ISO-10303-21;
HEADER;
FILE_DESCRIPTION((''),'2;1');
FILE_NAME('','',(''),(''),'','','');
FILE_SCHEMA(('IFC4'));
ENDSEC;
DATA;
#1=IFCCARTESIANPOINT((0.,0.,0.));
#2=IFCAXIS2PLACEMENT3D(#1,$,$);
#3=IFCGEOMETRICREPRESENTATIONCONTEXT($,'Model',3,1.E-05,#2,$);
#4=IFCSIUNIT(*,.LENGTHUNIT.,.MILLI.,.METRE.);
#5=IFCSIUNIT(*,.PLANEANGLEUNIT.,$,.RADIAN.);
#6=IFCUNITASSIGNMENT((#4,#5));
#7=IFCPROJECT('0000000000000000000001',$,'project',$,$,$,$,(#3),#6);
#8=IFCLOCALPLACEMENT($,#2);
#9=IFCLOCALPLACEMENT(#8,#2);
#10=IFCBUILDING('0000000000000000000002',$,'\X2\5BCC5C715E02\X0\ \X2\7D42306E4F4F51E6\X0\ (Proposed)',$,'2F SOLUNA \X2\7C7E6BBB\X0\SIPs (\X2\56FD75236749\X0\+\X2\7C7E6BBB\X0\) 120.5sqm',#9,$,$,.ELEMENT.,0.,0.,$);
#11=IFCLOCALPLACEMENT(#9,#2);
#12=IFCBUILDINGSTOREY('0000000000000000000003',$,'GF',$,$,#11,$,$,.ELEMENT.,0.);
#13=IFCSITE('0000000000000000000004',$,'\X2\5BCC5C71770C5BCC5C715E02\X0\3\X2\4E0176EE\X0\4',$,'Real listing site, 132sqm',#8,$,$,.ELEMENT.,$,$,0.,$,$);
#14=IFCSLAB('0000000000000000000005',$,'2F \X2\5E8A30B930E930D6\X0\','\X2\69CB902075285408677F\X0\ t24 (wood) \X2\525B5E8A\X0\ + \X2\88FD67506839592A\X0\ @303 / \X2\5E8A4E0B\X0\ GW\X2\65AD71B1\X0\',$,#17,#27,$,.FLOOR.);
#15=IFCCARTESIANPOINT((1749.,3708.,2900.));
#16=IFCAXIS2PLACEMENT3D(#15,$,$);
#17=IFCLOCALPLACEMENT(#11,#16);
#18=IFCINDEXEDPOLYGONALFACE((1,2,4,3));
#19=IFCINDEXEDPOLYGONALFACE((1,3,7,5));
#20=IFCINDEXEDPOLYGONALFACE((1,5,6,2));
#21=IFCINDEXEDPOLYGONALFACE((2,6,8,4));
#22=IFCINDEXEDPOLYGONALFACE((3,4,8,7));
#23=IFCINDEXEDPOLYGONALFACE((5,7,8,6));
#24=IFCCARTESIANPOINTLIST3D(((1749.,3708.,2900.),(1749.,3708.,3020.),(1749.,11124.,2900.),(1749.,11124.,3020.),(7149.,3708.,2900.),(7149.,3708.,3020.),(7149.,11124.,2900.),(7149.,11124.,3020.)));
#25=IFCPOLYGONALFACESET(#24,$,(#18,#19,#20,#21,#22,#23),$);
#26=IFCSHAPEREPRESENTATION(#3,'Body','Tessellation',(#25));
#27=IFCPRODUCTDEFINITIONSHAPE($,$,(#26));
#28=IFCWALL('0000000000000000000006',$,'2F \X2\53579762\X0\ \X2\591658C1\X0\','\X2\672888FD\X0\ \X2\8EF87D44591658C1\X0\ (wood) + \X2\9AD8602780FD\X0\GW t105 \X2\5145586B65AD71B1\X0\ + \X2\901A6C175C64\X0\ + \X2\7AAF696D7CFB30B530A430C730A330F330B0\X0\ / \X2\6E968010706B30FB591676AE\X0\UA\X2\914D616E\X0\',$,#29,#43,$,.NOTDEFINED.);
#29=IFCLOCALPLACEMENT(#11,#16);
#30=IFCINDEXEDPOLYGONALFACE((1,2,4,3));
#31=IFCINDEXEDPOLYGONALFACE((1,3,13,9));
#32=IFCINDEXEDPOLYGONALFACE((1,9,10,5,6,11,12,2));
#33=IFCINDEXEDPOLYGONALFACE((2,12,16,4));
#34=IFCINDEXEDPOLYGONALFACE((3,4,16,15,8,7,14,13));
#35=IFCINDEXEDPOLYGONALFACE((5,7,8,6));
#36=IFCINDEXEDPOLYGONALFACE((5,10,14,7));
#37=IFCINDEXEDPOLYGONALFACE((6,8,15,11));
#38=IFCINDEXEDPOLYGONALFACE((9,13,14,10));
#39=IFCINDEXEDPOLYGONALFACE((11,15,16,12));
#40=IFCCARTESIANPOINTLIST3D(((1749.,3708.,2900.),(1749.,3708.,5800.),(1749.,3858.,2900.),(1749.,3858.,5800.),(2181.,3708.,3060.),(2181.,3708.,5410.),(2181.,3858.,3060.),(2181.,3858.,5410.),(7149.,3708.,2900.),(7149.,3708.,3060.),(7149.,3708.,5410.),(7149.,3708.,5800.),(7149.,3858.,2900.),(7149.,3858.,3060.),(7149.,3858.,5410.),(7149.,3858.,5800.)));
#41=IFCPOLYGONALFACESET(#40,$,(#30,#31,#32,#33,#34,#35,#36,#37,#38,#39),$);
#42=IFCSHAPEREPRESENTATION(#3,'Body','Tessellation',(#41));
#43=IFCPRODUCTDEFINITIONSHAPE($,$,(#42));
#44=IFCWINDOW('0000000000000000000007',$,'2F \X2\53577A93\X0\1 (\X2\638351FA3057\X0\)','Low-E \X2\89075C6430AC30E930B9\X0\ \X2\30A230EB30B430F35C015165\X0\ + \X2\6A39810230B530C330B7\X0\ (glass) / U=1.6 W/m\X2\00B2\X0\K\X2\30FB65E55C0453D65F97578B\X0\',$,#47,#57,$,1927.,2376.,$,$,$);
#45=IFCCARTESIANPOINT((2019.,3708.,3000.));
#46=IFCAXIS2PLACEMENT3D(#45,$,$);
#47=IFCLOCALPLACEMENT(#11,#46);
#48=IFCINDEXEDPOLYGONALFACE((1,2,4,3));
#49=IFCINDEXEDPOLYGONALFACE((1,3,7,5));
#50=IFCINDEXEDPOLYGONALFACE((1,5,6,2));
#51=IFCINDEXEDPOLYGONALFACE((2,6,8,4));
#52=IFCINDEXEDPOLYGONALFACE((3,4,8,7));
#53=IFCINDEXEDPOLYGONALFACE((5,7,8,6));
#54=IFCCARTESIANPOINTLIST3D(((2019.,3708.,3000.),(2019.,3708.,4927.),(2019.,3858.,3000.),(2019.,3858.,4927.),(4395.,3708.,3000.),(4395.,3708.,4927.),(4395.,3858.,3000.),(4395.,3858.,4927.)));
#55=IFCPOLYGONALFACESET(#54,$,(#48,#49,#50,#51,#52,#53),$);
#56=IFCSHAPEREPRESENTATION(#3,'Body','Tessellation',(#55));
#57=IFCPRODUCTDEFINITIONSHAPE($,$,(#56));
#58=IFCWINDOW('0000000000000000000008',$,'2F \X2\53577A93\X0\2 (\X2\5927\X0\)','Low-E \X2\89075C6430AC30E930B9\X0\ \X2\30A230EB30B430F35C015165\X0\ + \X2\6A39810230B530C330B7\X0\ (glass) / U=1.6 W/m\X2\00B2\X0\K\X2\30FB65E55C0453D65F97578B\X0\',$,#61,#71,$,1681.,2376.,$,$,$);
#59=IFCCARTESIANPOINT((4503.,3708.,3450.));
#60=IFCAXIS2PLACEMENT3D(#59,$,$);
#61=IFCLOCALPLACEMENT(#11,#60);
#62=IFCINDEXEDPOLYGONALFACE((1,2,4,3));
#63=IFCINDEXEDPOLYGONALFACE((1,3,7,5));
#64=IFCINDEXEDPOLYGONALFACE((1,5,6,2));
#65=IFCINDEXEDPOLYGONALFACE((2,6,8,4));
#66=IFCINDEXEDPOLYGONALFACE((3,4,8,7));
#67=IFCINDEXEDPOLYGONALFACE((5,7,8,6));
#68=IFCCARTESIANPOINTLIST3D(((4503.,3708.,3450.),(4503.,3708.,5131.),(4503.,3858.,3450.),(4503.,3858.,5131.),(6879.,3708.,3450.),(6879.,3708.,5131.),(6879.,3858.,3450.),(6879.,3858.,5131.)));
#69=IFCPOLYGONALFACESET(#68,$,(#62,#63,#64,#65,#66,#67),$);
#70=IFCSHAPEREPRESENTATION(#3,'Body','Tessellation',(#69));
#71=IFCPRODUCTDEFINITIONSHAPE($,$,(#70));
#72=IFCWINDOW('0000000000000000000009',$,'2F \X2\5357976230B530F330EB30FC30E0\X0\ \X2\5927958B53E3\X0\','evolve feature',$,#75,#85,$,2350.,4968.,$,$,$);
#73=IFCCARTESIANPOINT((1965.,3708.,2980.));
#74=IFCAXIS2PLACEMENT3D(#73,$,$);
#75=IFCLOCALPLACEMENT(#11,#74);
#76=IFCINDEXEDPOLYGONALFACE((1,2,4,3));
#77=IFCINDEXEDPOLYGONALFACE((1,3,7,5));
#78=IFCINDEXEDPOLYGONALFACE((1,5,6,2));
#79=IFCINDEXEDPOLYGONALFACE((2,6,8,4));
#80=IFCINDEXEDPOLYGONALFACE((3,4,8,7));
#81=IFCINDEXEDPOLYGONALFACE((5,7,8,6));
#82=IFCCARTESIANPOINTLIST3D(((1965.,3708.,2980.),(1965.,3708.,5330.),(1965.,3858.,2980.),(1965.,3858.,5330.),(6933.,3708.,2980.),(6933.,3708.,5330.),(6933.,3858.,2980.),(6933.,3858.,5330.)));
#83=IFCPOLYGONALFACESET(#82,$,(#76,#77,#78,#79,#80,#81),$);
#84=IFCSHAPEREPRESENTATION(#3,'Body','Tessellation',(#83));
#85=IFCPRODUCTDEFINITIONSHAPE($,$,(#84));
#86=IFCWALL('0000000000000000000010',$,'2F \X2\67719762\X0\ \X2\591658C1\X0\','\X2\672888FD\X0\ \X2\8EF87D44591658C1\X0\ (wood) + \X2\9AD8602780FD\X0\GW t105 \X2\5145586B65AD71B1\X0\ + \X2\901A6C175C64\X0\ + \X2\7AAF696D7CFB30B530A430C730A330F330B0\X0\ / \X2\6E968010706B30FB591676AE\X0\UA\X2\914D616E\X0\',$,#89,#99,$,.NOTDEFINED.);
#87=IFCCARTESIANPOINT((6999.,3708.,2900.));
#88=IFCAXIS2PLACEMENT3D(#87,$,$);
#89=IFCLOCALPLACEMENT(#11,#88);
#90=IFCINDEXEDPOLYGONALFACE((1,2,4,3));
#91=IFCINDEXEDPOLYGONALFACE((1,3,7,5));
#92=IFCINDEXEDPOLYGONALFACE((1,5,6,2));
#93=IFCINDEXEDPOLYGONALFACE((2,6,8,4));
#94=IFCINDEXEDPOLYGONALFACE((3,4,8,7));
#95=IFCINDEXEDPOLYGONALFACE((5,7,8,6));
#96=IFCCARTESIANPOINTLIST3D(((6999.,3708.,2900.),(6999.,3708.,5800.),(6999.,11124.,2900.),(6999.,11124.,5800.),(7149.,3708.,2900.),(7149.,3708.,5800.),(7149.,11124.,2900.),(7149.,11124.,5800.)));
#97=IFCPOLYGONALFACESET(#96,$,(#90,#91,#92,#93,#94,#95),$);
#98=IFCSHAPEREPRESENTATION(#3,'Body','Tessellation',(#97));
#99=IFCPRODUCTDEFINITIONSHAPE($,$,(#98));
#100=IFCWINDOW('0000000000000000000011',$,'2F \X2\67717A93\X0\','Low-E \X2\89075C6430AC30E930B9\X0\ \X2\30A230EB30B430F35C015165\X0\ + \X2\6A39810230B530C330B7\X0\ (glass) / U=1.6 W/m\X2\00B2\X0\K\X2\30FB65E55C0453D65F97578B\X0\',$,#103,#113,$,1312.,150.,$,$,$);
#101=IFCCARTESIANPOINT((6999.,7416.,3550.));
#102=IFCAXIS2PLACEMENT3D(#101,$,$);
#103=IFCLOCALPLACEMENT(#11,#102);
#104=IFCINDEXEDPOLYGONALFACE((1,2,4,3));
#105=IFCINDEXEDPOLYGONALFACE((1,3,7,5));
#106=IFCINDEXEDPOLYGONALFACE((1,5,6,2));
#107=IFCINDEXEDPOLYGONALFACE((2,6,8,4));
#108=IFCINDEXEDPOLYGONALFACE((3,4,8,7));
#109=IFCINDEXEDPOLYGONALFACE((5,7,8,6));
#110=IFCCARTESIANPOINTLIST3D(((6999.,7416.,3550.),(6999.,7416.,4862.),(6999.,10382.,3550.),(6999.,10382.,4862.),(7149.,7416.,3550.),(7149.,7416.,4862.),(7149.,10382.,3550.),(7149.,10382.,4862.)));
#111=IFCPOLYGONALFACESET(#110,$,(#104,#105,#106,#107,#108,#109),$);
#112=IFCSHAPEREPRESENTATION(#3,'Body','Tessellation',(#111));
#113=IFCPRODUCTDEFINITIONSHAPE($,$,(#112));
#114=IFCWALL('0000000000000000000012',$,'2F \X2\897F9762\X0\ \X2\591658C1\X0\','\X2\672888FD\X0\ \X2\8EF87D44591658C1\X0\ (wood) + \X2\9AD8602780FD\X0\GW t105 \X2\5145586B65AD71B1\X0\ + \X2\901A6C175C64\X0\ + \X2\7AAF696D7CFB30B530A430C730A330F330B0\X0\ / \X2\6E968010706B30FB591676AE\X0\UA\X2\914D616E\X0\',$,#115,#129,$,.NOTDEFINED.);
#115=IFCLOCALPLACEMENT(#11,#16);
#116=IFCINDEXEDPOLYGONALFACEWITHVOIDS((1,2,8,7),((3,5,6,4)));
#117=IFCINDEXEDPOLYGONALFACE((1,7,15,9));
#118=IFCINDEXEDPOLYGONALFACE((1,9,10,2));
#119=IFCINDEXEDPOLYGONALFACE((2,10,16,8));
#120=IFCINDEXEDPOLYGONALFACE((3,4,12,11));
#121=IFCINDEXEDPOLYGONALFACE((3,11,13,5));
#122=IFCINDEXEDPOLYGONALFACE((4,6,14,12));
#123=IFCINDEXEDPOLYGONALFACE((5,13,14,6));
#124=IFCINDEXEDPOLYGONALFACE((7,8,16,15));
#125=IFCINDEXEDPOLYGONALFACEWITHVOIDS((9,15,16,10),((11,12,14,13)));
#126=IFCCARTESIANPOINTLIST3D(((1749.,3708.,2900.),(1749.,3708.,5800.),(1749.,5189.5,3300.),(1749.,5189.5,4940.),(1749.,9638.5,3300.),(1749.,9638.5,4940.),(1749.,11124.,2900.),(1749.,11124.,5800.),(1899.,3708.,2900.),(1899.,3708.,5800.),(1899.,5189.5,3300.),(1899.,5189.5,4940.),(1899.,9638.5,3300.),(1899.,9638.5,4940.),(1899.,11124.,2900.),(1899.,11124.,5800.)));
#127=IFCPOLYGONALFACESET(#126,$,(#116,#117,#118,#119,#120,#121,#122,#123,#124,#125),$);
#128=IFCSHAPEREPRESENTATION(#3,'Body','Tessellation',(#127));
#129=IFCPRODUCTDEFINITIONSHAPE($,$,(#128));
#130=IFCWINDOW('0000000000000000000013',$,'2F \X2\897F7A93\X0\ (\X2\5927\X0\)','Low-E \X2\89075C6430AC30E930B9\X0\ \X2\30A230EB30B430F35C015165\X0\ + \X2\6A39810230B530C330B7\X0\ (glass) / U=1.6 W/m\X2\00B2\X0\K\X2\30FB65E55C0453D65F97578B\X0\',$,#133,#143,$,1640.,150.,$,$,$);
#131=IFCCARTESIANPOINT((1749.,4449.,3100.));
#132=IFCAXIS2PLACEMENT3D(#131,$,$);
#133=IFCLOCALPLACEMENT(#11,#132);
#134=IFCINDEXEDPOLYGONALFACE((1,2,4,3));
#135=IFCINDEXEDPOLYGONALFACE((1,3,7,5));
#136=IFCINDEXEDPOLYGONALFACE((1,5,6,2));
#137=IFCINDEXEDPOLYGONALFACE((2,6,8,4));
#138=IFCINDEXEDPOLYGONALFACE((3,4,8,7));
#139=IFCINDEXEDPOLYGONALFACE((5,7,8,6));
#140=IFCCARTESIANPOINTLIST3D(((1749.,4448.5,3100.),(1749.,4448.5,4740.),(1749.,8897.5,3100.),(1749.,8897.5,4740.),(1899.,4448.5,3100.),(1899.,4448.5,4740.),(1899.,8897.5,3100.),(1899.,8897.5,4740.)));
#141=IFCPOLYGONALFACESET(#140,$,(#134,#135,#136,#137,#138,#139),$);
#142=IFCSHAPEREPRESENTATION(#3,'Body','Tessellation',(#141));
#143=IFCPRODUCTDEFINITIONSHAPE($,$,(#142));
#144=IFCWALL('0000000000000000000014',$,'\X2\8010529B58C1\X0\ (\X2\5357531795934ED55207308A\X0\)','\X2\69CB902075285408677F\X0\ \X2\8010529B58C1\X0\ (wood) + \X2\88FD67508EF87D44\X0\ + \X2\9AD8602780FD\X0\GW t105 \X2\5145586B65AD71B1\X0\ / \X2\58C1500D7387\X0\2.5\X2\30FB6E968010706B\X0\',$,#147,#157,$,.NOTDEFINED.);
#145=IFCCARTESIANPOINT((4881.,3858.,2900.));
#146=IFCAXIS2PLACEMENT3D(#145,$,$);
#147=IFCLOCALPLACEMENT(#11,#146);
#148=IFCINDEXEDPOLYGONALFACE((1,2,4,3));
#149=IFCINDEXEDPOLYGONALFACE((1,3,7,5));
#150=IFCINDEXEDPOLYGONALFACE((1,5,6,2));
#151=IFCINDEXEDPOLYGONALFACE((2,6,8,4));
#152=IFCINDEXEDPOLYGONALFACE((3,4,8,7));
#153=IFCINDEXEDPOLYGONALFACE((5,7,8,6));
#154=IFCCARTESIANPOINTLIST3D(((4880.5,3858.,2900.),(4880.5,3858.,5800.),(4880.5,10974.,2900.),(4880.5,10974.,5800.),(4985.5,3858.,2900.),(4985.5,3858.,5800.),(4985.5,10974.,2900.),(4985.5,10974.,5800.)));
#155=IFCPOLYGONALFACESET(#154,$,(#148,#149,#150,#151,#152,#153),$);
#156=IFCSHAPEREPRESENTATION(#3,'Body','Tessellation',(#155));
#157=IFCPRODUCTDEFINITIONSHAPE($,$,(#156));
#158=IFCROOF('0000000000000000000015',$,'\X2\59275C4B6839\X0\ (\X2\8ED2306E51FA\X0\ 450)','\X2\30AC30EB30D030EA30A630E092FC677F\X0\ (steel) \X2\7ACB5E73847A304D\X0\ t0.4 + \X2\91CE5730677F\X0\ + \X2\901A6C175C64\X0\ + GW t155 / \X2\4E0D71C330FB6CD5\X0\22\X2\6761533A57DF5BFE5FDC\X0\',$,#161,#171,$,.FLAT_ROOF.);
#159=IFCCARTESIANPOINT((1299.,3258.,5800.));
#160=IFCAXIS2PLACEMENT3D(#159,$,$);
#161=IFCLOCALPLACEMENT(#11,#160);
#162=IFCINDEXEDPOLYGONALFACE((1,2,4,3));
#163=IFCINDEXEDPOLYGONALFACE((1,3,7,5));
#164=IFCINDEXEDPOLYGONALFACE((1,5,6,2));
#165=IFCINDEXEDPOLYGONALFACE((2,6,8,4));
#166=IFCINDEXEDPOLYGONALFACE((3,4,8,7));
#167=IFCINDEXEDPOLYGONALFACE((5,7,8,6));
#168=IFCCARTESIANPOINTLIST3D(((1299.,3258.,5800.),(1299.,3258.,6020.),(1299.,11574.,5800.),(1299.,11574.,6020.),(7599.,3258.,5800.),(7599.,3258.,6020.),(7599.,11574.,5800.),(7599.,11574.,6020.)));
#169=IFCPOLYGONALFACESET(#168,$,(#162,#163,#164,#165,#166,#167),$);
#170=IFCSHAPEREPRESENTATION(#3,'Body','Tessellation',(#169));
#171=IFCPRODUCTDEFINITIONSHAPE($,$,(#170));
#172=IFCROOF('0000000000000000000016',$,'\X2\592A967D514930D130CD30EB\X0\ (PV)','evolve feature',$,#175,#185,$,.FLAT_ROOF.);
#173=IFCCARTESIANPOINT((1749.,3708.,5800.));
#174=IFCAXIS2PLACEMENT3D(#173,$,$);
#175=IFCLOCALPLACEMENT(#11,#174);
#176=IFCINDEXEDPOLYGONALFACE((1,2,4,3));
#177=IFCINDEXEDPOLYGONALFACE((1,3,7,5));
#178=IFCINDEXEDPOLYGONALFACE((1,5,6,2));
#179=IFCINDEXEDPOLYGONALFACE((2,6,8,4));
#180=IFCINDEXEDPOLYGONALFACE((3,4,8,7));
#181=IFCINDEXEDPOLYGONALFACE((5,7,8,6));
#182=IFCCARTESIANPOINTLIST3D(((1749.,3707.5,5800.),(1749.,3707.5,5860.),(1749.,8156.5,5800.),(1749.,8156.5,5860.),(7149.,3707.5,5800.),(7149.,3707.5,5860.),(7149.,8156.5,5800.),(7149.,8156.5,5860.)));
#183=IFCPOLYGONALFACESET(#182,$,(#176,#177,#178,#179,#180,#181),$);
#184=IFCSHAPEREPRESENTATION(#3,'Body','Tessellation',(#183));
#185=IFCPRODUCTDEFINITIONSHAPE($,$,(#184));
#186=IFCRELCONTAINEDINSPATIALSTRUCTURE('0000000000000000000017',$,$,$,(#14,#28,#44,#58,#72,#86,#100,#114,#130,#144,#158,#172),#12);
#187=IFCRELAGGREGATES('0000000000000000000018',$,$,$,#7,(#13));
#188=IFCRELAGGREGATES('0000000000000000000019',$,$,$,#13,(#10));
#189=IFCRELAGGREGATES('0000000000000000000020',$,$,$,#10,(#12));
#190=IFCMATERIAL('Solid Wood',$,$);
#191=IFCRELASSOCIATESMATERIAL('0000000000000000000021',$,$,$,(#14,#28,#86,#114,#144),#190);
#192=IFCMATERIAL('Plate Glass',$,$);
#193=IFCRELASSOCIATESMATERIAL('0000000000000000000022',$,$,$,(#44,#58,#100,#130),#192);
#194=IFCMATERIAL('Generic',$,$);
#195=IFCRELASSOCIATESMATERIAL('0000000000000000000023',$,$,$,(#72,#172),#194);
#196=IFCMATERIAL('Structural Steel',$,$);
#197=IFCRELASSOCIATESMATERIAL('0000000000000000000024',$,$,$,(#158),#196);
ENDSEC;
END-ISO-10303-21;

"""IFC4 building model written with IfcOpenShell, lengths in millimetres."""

from ifc_helpers import new_model, si_unit, frame, frame_2d, origin, place, context, project, spatial, rectangle, extrude, material, element, fill, save


model = new_model("IFC4")

# Units and contexts
model_context = context("Model", 3, precision=1e-05, world=origin())
ifc_project = project(units=[si_unit("LENGTHUNIT", "METRE", prefix="MILLI"), si_unit("PLANEANGLEUNIT", "RADIAN")], contexts=[model_context])

# Site, building, storey
site_placement = place(None, origin())
site = spatial("IfcSite", under=ifc_project, at=site_placement, Name="富山県富山市3丁目4", ObjectType="Real listing site, 132sqm", CompositionType="ELEMENT", RefElevation=0.0)
building_placement = place(site_placement, origin())
building = spatial("IfcBuilding", under=site, at=building_placement, Name="富山市 終の住処 (Proposed)", ObjectType="2F SOLUNA 籾殻SIPs (国産杉+籾殻) 120.5sqm", CompositionType="ELEMENT", ElevationOfRefHeight=0.0, ElevationOfTerrain=0.0)
storey_placement = place(building_placement, origin())
storey = spatial("IfcBuildingStorey", under=building, at=storey_placement, Name="GF", CompositionType="ELEMENT", Elevation=0.0)

# Slab
ifc_material_1 = material(Name="Solid Wood")
slab_placement = place(storey_placement, frame((1749.0, 3708.0, 2900.0)))
element("IfcSlab", 1, at=slab_placement, inside=storey, material=ifc_material_1, Name="2F 床スラブ", Description="構造用合板 t24 (wood) 剛床 + 製材根太 @303 / 床下 GW断熱", PredefinedType="FLOOR", context=model_context, shape_type="SweptSolid", body=[
    extrude(rectangle(XDim=5400.0, YDim=7416.0, at=frame_2d((2700.0, 3708.0))), frame((1749.0, 3708.0, 2900.0)), (0.0, 0.0, 1.0), 120.0),
])

# Wall, openings, windows
wall_1_placement = place(storey_placement, frame((1749.0, 3708.0, 2900.0)))
wall_1 = element("IfcWall", 2, at=wall_1_placement, inside=storey, material=ifc_material_1, Name="2F 南面 外壁", Description="木製 軸組外壁 (wood) + 高性能GW t105 充填断熱 + 通気層 + 窯業系サイディング / 準耐火・外皮UA配慮", PredefinedType="NOTDEFINED", context=model_context, shape_type="SweptSolid", body=[
    extrude(rectangle(XDim=5400.0, YDim=150.0, at=frame_2d((2700.0, 75.0))), frame((1749.0, 3708.0, 2900.0)), (0.0, 0.0, 1.0), 2900.0),
])
opening_1_placement = place(storey_placement, frame((2019.0, 3708.0, 3000.0)))
opening_1 = element("IfcOpeningElement", 3, at=opening_1_placement, cuts=wall_1, PredefinedType="NOTDEFINED", context=model_context, shape_type="SweptSolid", body=[
    extrude(rectangle(XDim=2376.0, YDim=150.0, at=frame_2d((1188.0, 75.0))), frame((2019.0, 3708.0, 3000.0)), (0.0, 0.0, 1.0), 1927.0),
])
opening_2_placement = place(storey_placement, frame((4503.0, 3708.0, 3450.0)))
opening_2 = element("IfcOpeningElement", 4, at=opening_2_placement, cuts=wall_1, PredefinedType="NOTDEFINED", context=model_context, shape_type="SweptSolid", body=[
    extrude(rectangle(XDim=2376.0, YDim=150.0, at=frame_2d((1188.0, 75.0))), frame((4503.0, 3708.0, 3450.0)), (0.0, 0.0, 1.0), 1681.0),
])
opening_3_placement = place(storey_placement, frame((1965.0, 3708.0, 2980.0)))
opening_3 = element("IfcOpeningElement", 5, at=opening_3_placement, cuts=wall_1, PredefinedType="NOTDEFINED", context=model_context, shape_type="SweptSolid", body=[
    extrude(rectangle(XDim=4968.0, YDim=150.0, at=frame_2d((2484.0, 75.0))), frame((1965.0, 3708.0, 2980.0)), (0.0, 0.0, 1.0), 2350.0),
])
ifc_material_2 = material(Name="Plate Glass")
window_1_placement = place(storey_placement, frame((2019.0, 3708.0, 3000.0)))
window_1 = element("IfcWindow", 6, at=window_1_placement, inside=storey, material=ifc_material_2, Name="2F 南窓1 (掃出し)", Description="Low-E 複層ガラス アルゴン封入 + 樹脂サッシ (glass) / U=1.6 W/m²K・日射取得型", OverallHeight=1927.0, OverallWidth=2376.0, context=model_context, shape_type="SweptSolid", body=[
    extrude(rectangle(XDim=2376.0, YDim=150.0, at=frame_2d((1188.0, 75.0))), frame((2019.0, 3708.0, 3000.0)), (0.0, 0.0, 1.0), 1927.0),
])
fill(opening_1, window_1)
window_2_placement = place(storey_placement, frame((4503.0, 3708.0, 3450.0)))
window_2 = element("IfcWindow", 7, at=window_2_placement, inside=storey, material=ifc_material_2, Name="2F 南窓2 (大)", Description="Low-E 複層ガラス アルゴン封入 + 樹脂サッシ (glass) / U=1.6 W/m²K・日射取得型", OverallHeight=1681.0, OverallWidth=2376.0, context=model_context, shape_type="SweptSolid", body=[
    extrude(rectangle(XDim=2376.0, YDim=150.0, at=frame_2d((1188.0, 75.0))), frame((4503.0, 3708.0, 3450.0)), (0.0, 0.0, 1.0), 1681.0),
])
fill(opening_2, window_2)
ifc_material_3 = material(Name="Generic")
window_3_placement = place(storey_placement, frame((1965.0, 3708.0, 2980.0)))
window_3 = element("IfcWindow", 8, at=window_3_placement, inside=storey, material=ifc_material_3, Name="2F 南面サンルーム 大開口", Description="evolve feature", OverallHeight=2350.0, OverallWidth=4968.0, context=model_context, shape_type="SweptSolid", body=[
    extrude(rectangle(XDim=4968.0, YDim=150.0, at=frame_2d((2484.0, 75.0))), frame((1965.0, 3708.0, 2980.0)), (0.0, 0.0, 1.0), 2350.0),
])
fill(opening_3, window_3)

# Walls, openings, windows
wall_2_placement = place(storey_placement, frame((6999.0, 3708.0, 2900.0)))
wall_2 = element("IfcWall", 9, at=wall_2_placement, inside=storey, material=ifc_material_1, Name="2F 東面 外壁", Description="木製 軸組外壁 (wood) + 高性能GW t105 充填断熱 + 通気層 + 窯業系サイディング / 準耐火・外皮UA配慮", PredefinedType="NOTDEFINED", context=model_context, shape_type="SweptSolid", body=[
    extrude(rectangle(XDim=150.0, YDim=7416.0, at=frame_2d((75.0, 3708.0))), frame((6999.0, 3708.0, 2900.0)), (0.0, 0.0, 1.0), 2900.0),
])
opening_4_placement = place(storey_placement, frame((6999.0, 7416.0, 3550.0)))
opening_4 = element("IfcOpeningElement", 10, at=opening_4_placement, cuts=wall_2, PredefinedType="NOTDEFINED", context=model_context, shape_type="SweptSolid", body=[
    extrude(rectangle(XDim=150.0, YDim=2966.0, at=frame_2d((75.0, 1483.0))), frame((6999.0, 7416.0, 3550.0)), (0.0, 0.0, 1.0), 1312.0),
])
window_4_placement = place(storey_placement, frame((6999.0, 7416.0, 3550.0)))
window_4 = element("IfcWindow", 11, at=window_4_placement, inside=storey, material=ifc_material_2, Name="2F 東窓", Description="Low-E 複層ガラス アルゴン封入 + 樹脂サッシ (glass) / U=1.6 W/m²K・日射取得型", OverallHeight=1312.0, OverallWidth=150.0, context=model_context, shape_type="SweptSolid", body=[
    extrude(rectangle(XDim=150.0, YDim=2966.0, at=frame_2d((75.0, 1483.0))), frame((6999.0, 7416.0, 3550.0)), (0.0, 0.0, 1.0), 1312.0),
])
fill(opening_4, window_4)
wall_3_placement = place(storey_placement, frame((1749.0, 3708.0, 2900.0)))
wall_3 = element("IfcWall", 12, at=wall_3_placement, inside=storey, material=ifc_material_1, Name="2F 西面 外壁", Description="木製 軸組外壁 (wood) + 高性能GW t105 充填断熱 + 通気層 + 窯業系サイディング / 準耐火・外皮UA配慮", PredefinedType="NOTDEFINED", context=model_context, shape_type="SweptSolid", body=[
    extrude(rectangle(XDim=150.0, YDim=7416.0, at=frame_2d((75.0, 3708.0))), frame((1749.0, 3708.0, 2900.0)), (0.0, 0.0, 1.0), 2900.0),
])
opening_5_placement = place(storey_placement, frame((1749.0, 4449.0, 3100.0)))
opening_5 = element("IfcOpeningElement", 13, at=opening_5_placement, cuts=wall_3, PredefinedType="NOTDEFINED", context=model_context, shape_type="SweptSolid", body=[
    extrude(rectangle(XDim=150.0, YDim=4449.0, at=frame_2d((75.0, 2224.0))), frame((1749.0, 4449.0, 3100.0)), (0.0, 0.0, 1.0), 1640.0),
])
window_5_placement = place(storey_placement, frame((1749.0, 4449.0, 3100.0)))
window_5 = element("IfcWindow", 14, at=window_5_placement, inside=storey, material=ifc_material_2, Name="2F 西窓 (大)", Description="Low-E 複層ガラス アルゴン封入 + 樹脂サッシ (glass) / U=1.6 W/m²K・日射取得型", OverallHeight=1640.0, OverallWidth=150.0, context=model_context, shape_type="SweptSolid", body=[
    extrude(rectangle(XDim=150.0, YDim=4449.0, at=frame_2d((75.0, 2224.0))), frame((1749.0, 4449.0, 3100.0)), (0.0, 0.0, 1.0), 1640.0),
])
fill(opening_5, window_5)

# Wall
wall_4_placement = place(storey_placement, frame((4881.0, 3858.0, 2900.0)))
element("IfcWall", 15, at=wall_4_placement, inside=storey, material=ifc_material_1, Name="耐力壁 (南北間仕切り)", Description="構造用合板 耐力壁 (wood) + 製材軸組 + 高性能GW t105 充填断熱 / 壁倍率2.5・準耐火", PredefinedType="NOTDEFINED", context=model_context, shape_type="SweptSolid", body=[
    extrude(rectangle(XDim=105.0, YDim=7116.0, at=frame_2d((52.0, 3558.0))), frame((4881.0, 3858.0, 2900.0)), (0.0, 0.0, 1.0), 2900.0),
])

# Roofs
ifc_material_4 = material(Name="Structural Steel")
roof_1_placement = place(storey_placement, frame((1299.0, 3258.0, 5800.0)))
element("IfcRoof", 16, at=roof_1_placement, inside=storey, material=ifc_material_4, Name="大屋根 (軒の出 450)", Description="ガルバリウム鋼板 (steel) 立平葺き t0.4 + 野地板 + 通気層 + GW t155 / 不燃・法22条区域対応", PredefinedType="FLAT_ROOF", context=model_context, shape_type="SweptSolid", body=[
    extrude(rectangle(XDim=6300.0, YDim=8316.0, at=frame_2d((3150.0, 4158.0))), frame((1299.0, 3258.0, 5800.0)), (0.0, 0.0, 1.0), 220.0),
])
roof_2_placement = place(storey_placement, frame((1749.0, 3708.0, 5800.0)))
element("IfcRoof", 17, at=roof_2_placement, inside=storey, material=ifc_material_3, Name="太陽光パネル (PV)", Description="evolve feature", PredefinedType="FLAT_ROOF", context=model_context, shape_type="SweptSolid", body=[
    extrude(rectangle(XDim=5400.0, YDim=4449.0, at=frame_2d((2700.0, 2224.0))), frame((1749.0, 3708.0, 5800.0)), (0.0, 0.0, 1.0), 60.0),
])

save(model, "model.ifc")
